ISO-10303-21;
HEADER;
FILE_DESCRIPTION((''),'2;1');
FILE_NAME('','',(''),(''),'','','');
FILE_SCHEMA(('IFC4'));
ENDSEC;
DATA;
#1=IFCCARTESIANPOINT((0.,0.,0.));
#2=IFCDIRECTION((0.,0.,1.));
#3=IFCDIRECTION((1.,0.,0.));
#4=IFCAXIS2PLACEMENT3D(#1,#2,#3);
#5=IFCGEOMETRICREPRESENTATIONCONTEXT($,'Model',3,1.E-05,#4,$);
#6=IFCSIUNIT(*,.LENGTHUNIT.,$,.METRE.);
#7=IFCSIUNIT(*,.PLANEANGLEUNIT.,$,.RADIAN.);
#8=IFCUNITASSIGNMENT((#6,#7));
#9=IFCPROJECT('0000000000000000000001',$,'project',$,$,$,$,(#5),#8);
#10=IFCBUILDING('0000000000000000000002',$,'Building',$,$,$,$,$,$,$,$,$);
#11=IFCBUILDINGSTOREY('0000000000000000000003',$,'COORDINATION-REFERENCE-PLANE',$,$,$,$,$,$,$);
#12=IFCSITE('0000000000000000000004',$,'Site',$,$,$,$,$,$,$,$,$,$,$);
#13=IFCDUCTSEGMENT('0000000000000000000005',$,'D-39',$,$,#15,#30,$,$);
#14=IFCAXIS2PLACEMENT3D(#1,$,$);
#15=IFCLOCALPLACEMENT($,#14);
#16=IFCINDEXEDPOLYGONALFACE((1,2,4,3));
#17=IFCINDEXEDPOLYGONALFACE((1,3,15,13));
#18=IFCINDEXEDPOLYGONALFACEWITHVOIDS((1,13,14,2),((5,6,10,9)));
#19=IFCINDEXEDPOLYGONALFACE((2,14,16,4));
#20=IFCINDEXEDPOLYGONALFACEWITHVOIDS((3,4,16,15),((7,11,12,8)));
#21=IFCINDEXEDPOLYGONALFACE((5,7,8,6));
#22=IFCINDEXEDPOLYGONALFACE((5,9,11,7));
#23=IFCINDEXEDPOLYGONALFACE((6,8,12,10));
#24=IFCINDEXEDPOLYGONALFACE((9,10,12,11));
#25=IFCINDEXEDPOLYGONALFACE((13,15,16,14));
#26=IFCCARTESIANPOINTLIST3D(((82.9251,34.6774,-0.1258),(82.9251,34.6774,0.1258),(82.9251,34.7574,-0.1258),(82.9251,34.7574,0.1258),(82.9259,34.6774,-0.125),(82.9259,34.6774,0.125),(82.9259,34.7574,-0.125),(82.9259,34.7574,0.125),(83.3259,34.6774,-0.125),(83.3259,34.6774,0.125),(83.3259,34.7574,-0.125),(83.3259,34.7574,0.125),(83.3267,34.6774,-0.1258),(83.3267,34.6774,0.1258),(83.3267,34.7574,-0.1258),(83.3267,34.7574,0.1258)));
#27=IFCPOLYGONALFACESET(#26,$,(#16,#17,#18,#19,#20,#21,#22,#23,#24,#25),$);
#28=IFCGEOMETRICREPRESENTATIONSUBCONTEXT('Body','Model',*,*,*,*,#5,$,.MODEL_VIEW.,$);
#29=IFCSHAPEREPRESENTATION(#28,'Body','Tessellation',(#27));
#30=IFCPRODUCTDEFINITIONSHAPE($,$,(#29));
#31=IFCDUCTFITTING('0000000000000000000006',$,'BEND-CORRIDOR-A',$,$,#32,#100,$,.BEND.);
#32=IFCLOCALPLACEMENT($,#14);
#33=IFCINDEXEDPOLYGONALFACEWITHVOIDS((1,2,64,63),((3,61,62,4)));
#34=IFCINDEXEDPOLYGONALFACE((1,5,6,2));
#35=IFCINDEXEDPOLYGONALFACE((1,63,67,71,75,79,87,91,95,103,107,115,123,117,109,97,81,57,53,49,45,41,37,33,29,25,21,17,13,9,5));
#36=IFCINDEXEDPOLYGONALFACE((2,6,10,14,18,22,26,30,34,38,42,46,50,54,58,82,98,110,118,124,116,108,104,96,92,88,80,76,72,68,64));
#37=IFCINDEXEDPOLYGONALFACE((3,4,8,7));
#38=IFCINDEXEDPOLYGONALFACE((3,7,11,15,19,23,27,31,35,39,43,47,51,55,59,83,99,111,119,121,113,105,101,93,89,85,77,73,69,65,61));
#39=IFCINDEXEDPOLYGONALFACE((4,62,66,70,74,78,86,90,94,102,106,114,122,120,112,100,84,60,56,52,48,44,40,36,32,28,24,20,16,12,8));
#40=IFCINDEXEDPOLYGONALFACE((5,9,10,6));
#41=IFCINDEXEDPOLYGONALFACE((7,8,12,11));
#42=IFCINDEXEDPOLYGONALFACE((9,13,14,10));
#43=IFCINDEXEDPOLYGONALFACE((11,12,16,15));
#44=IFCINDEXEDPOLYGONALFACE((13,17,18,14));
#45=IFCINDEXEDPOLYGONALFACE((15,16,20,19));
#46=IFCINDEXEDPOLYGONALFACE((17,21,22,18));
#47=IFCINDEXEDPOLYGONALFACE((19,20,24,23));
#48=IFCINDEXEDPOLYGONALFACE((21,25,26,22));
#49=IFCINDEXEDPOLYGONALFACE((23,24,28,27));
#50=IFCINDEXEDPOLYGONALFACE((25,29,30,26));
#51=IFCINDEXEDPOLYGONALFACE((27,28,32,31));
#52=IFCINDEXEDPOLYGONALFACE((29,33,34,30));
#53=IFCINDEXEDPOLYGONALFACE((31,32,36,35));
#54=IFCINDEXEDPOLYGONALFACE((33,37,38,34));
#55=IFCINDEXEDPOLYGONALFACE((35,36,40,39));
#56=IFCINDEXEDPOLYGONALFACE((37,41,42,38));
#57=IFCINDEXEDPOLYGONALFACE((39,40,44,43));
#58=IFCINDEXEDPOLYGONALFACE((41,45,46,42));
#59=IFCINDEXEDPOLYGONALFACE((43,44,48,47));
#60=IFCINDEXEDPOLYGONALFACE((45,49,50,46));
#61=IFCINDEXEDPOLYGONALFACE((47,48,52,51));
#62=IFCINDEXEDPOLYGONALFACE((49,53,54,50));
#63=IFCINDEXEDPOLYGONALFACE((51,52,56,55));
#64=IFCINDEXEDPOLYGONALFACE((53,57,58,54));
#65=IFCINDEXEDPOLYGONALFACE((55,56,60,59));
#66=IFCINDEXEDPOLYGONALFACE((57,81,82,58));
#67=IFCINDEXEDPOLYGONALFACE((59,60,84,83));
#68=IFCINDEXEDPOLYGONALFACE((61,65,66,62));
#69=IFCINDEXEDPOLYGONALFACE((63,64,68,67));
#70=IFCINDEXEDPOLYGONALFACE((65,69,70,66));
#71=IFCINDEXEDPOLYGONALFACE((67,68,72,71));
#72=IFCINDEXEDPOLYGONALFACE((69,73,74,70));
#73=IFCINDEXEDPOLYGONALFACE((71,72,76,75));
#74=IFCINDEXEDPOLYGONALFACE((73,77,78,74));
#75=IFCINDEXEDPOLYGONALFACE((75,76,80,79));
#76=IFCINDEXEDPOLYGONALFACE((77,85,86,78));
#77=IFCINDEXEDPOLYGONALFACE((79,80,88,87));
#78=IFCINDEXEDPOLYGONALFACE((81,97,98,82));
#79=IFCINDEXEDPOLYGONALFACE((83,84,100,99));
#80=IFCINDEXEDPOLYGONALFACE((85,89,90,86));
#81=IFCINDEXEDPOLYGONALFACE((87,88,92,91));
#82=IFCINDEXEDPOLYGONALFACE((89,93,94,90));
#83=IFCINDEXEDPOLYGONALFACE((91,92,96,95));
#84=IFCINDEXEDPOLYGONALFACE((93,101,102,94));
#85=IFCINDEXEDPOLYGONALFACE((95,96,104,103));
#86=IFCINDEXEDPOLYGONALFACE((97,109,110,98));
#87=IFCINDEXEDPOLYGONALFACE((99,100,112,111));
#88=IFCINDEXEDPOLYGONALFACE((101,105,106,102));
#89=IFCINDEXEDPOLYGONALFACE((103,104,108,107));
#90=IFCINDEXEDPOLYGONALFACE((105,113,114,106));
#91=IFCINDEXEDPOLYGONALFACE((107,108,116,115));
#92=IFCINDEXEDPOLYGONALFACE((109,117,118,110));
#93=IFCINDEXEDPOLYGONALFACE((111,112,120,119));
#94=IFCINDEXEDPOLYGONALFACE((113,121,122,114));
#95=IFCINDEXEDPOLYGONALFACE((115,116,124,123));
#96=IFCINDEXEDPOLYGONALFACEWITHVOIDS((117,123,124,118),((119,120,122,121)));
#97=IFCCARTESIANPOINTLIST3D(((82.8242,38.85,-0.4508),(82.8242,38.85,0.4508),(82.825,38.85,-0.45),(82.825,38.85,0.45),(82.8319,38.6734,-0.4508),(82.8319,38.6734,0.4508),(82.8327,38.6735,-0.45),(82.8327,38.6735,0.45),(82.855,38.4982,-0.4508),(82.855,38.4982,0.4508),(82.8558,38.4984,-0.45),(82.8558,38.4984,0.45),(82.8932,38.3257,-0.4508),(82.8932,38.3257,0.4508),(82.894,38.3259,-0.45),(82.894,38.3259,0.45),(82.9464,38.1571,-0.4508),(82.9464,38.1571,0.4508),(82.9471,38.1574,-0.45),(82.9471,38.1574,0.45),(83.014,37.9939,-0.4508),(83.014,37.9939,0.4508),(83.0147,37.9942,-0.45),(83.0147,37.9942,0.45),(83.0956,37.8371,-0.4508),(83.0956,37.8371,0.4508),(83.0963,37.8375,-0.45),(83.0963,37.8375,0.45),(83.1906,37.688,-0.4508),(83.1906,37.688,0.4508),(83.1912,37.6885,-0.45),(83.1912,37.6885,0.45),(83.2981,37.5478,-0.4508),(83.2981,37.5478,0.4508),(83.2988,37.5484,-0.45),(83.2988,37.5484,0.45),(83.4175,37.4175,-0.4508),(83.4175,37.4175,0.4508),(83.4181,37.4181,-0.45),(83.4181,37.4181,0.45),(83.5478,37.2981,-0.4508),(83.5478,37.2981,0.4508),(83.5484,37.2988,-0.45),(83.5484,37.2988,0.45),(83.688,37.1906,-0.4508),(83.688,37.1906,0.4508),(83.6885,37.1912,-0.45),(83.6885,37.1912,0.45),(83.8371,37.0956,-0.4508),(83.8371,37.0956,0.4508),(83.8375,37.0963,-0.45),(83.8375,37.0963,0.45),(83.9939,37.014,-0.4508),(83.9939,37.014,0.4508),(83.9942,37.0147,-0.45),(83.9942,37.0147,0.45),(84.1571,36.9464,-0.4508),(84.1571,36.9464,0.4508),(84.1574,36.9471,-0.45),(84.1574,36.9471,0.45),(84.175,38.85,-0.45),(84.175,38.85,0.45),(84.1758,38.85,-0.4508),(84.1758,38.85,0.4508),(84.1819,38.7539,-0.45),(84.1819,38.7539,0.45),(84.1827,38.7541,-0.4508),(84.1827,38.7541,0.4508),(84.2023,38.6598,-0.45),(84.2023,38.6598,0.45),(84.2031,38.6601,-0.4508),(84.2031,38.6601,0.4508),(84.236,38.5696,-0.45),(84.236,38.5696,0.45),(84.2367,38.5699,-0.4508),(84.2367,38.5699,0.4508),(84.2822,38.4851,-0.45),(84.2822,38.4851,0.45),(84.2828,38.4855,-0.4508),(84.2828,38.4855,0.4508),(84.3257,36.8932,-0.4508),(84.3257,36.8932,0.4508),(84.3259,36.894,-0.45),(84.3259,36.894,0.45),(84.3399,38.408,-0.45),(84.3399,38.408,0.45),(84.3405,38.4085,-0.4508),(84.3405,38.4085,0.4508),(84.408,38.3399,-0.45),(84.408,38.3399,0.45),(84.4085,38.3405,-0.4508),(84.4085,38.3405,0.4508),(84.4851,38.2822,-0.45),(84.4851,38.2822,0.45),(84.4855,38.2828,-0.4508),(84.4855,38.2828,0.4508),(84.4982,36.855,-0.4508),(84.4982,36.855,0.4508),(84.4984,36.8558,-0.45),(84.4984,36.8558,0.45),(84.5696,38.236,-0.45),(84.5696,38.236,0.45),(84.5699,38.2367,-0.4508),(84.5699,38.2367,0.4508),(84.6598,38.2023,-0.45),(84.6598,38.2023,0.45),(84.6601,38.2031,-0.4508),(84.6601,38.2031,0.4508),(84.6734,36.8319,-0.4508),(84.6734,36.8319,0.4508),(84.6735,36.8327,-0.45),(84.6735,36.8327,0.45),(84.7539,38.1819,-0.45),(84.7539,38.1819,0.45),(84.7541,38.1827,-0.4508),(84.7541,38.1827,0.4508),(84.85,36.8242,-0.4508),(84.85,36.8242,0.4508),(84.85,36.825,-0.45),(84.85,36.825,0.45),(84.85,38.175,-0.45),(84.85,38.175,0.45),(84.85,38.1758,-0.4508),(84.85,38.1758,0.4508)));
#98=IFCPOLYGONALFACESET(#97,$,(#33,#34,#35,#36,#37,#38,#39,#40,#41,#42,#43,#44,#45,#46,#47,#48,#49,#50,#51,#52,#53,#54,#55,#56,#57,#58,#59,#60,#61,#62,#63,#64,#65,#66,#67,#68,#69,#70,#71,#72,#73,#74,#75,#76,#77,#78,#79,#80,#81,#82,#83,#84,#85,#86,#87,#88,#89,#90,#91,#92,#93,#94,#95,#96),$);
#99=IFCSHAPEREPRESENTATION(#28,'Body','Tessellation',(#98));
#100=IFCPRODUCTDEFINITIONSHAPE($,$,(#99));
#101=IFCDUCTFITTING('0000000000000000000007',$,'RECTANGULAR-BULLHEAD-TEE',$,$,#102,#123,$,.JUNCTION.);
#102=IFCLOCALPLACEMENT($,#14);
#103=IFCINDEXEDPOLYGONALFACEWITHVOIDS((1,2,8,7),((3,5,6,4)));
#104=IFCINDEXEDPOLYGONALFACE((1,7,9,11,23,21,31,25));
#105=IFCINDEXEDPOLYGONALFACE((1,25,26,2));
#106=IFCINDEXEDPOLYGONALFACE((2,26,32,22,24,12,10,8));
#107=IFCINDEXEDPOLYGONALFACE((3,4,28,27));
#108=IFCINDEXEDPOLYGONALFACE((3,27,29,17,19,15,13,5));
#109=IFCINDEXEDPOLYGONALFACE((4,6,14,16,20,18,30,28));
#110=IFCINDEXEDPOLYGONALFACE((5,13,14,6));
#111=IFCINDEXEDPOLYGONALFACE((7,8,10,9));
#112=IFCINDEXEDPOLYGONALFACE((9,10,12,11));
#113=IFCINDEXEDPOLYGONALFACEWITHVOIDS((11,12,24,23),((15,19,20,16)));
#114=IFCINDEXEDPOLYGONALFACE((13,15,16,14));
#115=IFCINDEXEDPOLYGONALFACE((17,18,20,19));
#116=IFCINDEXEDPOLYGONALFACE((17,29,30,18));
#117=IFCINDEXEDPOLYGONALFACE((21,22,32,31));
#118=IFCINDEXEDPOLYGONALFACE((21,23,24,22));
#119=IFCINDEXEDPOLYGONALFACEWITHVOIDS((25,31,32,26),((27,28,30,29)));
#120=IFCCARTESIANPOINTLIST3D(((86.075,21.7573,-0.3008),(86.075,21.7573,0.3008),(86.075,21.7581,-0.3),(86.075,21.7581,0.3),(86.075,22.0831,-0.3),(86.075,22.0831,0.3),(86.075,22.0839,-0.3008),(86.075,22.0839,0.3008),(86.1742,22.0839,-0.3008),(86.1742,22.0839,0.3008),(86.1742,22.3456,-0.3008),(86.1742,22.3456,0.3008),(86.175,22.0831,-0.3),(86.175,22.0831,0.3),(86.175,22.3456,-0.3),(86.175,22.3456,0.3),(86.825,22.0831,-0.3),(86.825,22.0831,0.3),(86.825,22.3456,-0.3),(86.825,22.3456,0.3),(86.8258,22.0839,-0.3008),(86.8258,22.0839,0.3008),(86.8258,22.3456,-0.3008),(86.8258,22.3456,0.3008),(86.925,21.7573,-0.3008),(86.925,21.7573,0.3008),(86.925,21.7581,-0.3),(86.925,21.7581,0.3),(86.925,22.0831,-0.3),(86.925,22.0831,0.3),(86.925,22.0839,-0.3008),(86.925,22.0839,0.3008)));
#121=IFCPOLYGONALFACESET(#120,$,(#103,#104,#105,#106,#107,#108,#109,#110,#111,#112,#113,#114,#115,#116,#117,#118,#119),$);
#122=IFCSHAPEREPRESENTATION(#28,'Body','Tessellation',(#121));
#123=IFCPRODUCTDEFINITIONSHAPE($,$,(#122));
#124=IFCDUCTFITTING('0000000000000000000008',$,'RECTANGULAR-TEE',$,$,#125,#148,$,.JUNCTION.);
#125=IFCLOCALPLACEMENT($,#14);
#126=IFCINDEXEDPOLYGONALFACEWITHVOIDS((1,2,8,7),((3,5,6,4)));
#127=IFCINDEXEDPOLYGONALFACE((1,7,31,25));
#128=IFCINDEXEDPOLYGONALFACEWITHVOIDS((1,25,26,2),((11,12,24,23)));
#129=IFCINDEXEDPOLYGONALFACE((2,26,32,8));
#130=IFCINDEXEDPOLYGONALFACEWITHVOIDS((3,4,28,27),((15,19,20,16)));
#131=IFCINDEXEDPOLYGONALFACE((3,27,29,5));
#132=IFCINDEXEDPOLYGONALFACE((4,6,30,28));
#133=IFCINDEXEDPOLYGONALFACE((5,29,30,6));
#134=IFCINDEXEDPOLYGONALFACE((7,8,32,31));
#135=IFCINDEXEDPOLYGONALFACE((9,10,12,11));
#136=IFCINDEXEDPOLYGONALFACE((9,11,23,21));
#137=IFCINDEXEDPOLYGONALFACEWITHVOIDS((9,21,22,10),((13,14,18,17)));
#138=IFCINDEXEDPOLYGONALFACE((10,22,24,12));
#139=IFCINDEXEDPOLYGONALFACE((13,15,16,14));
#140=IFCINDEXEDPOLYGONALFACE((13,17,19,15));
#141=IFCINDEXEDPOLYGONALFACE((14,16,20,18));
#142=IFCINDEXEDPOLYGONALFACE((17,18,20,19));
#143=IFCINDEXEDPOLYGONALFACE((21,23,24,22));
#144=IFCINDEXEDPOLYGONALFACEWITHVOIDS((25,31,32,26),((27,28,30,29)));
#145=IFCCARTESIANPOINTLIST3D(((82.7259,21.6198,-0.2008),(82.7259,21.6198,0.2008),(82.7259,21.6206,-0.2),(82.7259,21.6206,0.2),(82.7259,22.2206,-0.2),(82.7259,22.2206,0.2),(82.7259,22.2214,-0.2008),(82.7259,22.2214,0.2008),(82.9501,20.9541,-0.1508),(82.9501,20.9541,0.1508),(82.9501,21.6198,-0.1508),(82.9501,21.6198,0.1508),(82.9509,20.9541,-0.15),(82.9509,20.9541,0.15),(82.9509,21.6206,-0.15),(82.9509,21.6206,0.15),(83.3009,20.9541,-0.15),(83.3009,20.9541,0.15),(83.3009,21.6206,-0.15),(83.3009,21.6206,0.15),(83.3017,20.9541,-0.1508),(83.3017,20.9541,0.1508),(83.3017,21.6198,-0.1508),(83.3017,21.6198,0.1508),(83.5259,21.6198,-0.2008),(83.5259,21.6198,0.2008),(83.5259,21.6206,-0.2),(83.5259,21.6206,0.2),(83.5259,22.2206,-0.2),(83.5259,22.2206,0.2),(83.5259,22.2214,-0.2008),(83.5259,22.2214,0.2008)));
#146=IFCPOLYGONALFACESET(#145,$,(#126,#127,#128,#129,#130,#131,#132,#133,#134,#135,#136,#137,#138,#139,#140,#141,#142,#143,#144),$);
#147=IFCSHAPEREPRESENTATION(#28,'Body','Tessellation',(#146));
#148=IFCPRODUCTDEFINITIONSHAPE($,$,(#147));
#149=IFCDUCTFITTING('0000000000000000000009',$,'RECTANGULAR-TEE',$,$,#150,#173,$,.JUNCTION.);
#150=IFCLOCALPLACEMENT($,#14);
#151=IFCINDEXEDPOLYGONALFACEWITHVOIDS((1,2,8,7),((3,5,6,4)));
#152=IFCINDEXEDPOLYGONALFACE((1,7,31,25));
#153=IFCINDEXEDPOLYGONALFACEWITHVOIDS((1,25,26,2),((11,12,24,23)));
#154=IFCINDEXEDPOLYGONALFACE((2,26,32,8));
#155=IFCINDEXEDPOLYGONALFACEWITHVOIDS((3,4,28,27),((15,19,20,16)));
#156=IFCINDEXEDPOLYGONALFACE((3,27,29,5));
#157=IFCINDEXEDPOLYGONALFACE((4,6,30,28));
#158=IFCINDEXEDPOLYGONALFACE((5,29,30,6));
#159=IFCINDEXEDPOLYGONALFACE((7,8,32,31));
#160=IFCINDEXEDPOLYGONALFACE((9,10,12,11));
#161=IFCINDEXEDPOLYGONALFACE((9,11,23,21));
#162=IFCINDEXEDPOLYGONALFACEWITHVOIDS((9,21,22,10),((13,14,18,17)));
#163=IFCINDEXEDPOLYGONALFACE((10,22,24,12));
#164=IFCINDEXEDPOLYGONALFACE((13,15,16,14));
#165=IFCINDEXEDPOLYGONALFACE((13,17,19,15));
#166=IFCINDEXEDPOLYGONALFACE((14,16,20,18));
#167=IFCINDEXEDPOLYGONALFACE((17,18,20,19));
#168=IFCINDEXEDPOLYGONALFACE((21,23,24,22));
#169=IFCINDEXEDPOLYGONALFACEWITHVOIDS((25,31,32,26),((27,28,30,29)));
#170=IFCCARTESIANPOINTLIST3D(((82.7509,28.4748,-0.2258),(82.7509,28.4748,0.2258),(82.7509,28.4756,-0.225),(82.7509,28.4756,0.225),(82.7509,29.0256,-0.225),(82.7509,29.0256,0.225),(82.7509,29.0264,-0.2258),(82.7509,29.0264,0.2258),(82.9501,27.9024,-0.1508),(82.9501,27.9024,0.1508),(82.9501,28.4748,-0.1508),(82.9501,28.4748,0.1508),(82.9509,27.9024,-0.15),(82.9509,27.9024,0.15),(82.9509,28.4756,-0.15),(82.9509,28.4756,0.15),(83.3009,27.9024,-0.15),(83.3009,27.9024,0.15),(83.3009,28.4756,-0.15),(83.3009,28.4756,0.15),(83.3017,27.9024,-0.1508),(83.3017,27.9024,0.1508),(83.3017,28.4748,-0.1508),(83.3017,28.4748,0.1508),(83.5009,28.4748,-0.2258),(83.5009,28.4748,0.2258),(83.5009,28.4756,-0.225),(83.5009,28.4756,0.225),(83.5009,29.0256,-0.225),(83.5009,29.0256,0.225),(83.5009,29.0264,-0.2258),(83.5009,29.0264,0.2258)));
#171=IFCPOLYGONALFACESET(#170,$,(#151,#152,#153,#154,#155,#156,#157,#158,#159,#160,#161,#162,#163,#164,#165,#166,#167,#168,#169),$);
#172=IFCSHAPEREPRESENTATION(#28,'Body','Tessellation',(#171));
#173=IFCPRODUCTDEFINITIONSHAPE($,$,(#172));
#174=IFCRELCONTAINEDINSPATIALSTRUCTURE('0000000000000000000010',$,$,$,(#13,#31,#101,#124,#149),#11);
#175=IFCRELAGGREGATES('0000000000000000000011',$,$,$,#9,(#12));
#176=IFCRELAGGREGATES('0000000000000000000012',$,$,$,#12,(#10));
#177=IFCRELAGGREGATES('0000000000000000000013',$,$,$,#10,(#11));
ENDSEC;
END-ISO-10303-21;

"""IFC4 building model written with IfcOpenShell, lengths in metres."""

from ifc_helpers import new_model, entity, si_unit, frame, origin, origin_with_axes, place, context, subcontext, project, spatial, rectangle, hollow_rectangle, extrude, boolean, element, save


model = new_model("IFC4")

# Units and contexts
model_context = context("Model", 3, precision=1e-05, world=origin_with_axes())
body_context_1 = subcontext(model_context, "Body", "Model", "MODEL_VIEW")
ifc_project = project(units=[si_unit("LENGTHUNIT", "METRE"), si_unit("PLANEANGLEUNIT", "RADIAN")], contexts=[model_context])

# Site, building, storey
site = spatial("IfcSite", under=ifc_project, Name="Site")
building = spatial("IfcBuilding", under=site, Name="Building")
storey = spatial("IfcBuildingStorey", under=building, Name="COORDINATION-REFERENCE-PLANE")

# Duct segment
duct_segment_1_placement = place(None, frame((83.1259, 34.6774, 0.0), z_axis=(0.0, 1.0, 0.0), x_axis=(1.0, 0.0, 0.0)))
element("IfcDuctSegment", 1, at=duct_segment_1_placement, inside=storey, Name="D-39", context=body_context_1, shape_type="SweptSolid", body=[
    extrude(hollow_rectangle(XDim=0.4016, YDim=0.2516, WallThickness=0.0008), origin(), (0.0, 0.0, 1.0), 0.08),
])

# Duct fittings
duct_fitting_1_placement = place(None, frame((84.85, 38.85, 0.0), z_axis=(0.0, 0.0, 1.0), x_axis=(-1.0, 0.0, 0.0)))
cartesian_point_1 = entity("IfcCartesianPoint", [0.0, 0.0, 0.0])
element("IfcDuctFitting", 2, at=duct_fitting_1_placement, inside=storey, Name="BEND-CORRIDOR-A", PredefinedType="BEND", context=body_context_1, shape_type="SweptSolid", body=[
    entity("IfcRevolvedAreaSolid", entity("IfcRectangleHollowProfileDef", "AREA", None, entity("IfcAxis2Placement2D", entity("IfcCartesianPoint", [1.35, 0.0])), 1.3516, 0.9016, 0.0008), entity("IfcAxis2Placement3D", cartesian_point_1, entity("IfcDirection", [0.0, -1.0, 0.0]), entity("IfcDirection", [1.0, 0.0, 0.0])), entity("IfcAxis1Placement", cartesian_point_1, entity("IfcDirection", [0.0, 1.0, 0.0])), 1.570796),
])
duct_fitting_2_placement = place(None, frame((86.5, 21.9206, 0.0), z_axis=(1.0, 0.0, 0.0), x_axis=(0.0, 1.0, 0.0)))
solid_1 = boolean("UNION", extrude(rectangle(XDim=0.325, YDim=0.6), frame((0.0, 0.0, -0.425), z_axis=(0.0, 0.0, 1.0), x_axis=(1.0, 0.0, 0.0)), (0.0, 0.0, 1.0), 0.85), extrude(rectangle(XDim=0.65, YDim=0.6), frame((0.0, 0.0, 0.0), z_axis=(1.0, 0.0, 0.0), x_axis=(0.0, 0.0, -1.0)), (0.0, 0.0, 1.0), 0.425))
element("IfcDuctFitting", 3, at=duct_fitting_2_placement, inside=storey, Name="RECTANGULAR-BULLHEAD-TEE", PredefinedType="JUNCTION", context=body_context_1, shape_type="CSG", body=[
    boolean("DIFFERENCE", boolean("UNION", extrude(rectangle(XDim=0.3266, YDim=0.6016), frame((0.0, 0.0, -0.425), z_axis=(0.0, 0.0, 1.0), x_axis=(1.0, 0.0, 0.0)), (0.0, 0.0, 1.0), 0.85), extrude(rectangle(XDim=0.6516, YDim=0.6016), frame((0.0, 0.0, 0.0), z_axis=(1.0, 0.0, 0.0), x_axis=(0.0, 0.0, -1.0)), (0.0, 0.0, 1.0), 0.425)), solid_1),
])
duct_fitting_3_placement = place(None, frame((83.1259, 21.9206, 0.0), z_axis=(-1.0, 0.0, 0.0), x_axis=(0.0, -1.0, 0.0)))
solid_2 = boolean("UNION", extrude(rectangle(XDim=0.6, YDim=0.4), frame((0.0, 0.0, -0.4), z_axis=(0.0, 0.0, 1.0), x_axis=(1.0, 0.0, 0.0)), (0.0, 0.0, 1.0), 0.8), extrude(rectangle(XDim=0.35, YDim=0.3), frame((0.0, 0.0, 0.0), z_axis=(1.0, 0.0, 0.0), x_axis=(0.0, 0.0, -1.0)), (0.0, 0.0, 1.0), 0.9665))
element("IfcDuctFitting", 4, at=duct_fitting_3_placement, inside=storey, Name="RECTANGULAR-TEE", PredefinedType="JUNCTION", context=body_context_1, shape_type="CSG", body=[
    boolean("DIFFERENCE", boolean("UNION", extrude(rectangle(XDim=0.6016, YDim=0.4016), frame((0.0, 0.0, -0.4), z_axis=(0.0, 0.0, 1.0), x_axis=(1.0, 0.0, 0.0)), (0.0, 0.0, 1.0), 0.8), extrude(rectangle(XDim=0.3516, YDim=0.3016), frame((0.0, 0.0, 0.0), z_axis=(1.0, 0.0, 0.0), x_axis=(0.0, 0.0, -1.0)), (0.0, 0.0, 1.0), 0.9665)), solid_2),
])
duct_fitting_4_placement = place(None, frame((83.1259, 28.7506, 0.0), z_axis=(-1.0, 0.0, 0.0), x_axis=(0.0, -1.0, 0.0)))
solid_3 = boolean("UNION", extrude(rectangle(XDim=0.55, YDim=0.45), frame((0.0, 0.0, -0.375), z_axis=(0.0, 0.0, 1.0), x_axis=(1.0, 0.0, 0.0)), (0.0, 0.0, 1.0), 0.75), extrude(rectangle(XDim=0.35, YDim=0.3), frame((0.0, 0.0, 0.0), z_axis=(1.0, 0.0, 0.0), x_axis=(0.0, 0.0, -1.0)), (0.0, 0.0, 1.0), 0.8482))
element("IfcDuctFitting", 5, at=duct_fitting_4_placement, inside=storey, Name="RECTANGULAR-TEE", PredefinedType="JUNCTION", context=body_context_1, shape_type="CSG", body=[
    boolean("DIFFERENCE", boolean("UNION", extrude(rectangle(XDim=0.5516, YDim=0.4516), frame((0.0, 0.0, -0.375), z_axis=(0.0, 0.0, 1.0), x_axis=(1.0, 0.0, 0.0)), (0.0, 0.0, 1.0), 0.75), extrude(rectangle(XDim=0.3516, YDim=0.3016), frame((0.0, 0.0, 0.0), z_axis=(1.0, 0.0, 0.0), x_axis=(0.0, 0.0, -1.0)), (0.0, 0.0, 1.0), 0.8482)), solid_3),
])

save(model, "model.ifc")
